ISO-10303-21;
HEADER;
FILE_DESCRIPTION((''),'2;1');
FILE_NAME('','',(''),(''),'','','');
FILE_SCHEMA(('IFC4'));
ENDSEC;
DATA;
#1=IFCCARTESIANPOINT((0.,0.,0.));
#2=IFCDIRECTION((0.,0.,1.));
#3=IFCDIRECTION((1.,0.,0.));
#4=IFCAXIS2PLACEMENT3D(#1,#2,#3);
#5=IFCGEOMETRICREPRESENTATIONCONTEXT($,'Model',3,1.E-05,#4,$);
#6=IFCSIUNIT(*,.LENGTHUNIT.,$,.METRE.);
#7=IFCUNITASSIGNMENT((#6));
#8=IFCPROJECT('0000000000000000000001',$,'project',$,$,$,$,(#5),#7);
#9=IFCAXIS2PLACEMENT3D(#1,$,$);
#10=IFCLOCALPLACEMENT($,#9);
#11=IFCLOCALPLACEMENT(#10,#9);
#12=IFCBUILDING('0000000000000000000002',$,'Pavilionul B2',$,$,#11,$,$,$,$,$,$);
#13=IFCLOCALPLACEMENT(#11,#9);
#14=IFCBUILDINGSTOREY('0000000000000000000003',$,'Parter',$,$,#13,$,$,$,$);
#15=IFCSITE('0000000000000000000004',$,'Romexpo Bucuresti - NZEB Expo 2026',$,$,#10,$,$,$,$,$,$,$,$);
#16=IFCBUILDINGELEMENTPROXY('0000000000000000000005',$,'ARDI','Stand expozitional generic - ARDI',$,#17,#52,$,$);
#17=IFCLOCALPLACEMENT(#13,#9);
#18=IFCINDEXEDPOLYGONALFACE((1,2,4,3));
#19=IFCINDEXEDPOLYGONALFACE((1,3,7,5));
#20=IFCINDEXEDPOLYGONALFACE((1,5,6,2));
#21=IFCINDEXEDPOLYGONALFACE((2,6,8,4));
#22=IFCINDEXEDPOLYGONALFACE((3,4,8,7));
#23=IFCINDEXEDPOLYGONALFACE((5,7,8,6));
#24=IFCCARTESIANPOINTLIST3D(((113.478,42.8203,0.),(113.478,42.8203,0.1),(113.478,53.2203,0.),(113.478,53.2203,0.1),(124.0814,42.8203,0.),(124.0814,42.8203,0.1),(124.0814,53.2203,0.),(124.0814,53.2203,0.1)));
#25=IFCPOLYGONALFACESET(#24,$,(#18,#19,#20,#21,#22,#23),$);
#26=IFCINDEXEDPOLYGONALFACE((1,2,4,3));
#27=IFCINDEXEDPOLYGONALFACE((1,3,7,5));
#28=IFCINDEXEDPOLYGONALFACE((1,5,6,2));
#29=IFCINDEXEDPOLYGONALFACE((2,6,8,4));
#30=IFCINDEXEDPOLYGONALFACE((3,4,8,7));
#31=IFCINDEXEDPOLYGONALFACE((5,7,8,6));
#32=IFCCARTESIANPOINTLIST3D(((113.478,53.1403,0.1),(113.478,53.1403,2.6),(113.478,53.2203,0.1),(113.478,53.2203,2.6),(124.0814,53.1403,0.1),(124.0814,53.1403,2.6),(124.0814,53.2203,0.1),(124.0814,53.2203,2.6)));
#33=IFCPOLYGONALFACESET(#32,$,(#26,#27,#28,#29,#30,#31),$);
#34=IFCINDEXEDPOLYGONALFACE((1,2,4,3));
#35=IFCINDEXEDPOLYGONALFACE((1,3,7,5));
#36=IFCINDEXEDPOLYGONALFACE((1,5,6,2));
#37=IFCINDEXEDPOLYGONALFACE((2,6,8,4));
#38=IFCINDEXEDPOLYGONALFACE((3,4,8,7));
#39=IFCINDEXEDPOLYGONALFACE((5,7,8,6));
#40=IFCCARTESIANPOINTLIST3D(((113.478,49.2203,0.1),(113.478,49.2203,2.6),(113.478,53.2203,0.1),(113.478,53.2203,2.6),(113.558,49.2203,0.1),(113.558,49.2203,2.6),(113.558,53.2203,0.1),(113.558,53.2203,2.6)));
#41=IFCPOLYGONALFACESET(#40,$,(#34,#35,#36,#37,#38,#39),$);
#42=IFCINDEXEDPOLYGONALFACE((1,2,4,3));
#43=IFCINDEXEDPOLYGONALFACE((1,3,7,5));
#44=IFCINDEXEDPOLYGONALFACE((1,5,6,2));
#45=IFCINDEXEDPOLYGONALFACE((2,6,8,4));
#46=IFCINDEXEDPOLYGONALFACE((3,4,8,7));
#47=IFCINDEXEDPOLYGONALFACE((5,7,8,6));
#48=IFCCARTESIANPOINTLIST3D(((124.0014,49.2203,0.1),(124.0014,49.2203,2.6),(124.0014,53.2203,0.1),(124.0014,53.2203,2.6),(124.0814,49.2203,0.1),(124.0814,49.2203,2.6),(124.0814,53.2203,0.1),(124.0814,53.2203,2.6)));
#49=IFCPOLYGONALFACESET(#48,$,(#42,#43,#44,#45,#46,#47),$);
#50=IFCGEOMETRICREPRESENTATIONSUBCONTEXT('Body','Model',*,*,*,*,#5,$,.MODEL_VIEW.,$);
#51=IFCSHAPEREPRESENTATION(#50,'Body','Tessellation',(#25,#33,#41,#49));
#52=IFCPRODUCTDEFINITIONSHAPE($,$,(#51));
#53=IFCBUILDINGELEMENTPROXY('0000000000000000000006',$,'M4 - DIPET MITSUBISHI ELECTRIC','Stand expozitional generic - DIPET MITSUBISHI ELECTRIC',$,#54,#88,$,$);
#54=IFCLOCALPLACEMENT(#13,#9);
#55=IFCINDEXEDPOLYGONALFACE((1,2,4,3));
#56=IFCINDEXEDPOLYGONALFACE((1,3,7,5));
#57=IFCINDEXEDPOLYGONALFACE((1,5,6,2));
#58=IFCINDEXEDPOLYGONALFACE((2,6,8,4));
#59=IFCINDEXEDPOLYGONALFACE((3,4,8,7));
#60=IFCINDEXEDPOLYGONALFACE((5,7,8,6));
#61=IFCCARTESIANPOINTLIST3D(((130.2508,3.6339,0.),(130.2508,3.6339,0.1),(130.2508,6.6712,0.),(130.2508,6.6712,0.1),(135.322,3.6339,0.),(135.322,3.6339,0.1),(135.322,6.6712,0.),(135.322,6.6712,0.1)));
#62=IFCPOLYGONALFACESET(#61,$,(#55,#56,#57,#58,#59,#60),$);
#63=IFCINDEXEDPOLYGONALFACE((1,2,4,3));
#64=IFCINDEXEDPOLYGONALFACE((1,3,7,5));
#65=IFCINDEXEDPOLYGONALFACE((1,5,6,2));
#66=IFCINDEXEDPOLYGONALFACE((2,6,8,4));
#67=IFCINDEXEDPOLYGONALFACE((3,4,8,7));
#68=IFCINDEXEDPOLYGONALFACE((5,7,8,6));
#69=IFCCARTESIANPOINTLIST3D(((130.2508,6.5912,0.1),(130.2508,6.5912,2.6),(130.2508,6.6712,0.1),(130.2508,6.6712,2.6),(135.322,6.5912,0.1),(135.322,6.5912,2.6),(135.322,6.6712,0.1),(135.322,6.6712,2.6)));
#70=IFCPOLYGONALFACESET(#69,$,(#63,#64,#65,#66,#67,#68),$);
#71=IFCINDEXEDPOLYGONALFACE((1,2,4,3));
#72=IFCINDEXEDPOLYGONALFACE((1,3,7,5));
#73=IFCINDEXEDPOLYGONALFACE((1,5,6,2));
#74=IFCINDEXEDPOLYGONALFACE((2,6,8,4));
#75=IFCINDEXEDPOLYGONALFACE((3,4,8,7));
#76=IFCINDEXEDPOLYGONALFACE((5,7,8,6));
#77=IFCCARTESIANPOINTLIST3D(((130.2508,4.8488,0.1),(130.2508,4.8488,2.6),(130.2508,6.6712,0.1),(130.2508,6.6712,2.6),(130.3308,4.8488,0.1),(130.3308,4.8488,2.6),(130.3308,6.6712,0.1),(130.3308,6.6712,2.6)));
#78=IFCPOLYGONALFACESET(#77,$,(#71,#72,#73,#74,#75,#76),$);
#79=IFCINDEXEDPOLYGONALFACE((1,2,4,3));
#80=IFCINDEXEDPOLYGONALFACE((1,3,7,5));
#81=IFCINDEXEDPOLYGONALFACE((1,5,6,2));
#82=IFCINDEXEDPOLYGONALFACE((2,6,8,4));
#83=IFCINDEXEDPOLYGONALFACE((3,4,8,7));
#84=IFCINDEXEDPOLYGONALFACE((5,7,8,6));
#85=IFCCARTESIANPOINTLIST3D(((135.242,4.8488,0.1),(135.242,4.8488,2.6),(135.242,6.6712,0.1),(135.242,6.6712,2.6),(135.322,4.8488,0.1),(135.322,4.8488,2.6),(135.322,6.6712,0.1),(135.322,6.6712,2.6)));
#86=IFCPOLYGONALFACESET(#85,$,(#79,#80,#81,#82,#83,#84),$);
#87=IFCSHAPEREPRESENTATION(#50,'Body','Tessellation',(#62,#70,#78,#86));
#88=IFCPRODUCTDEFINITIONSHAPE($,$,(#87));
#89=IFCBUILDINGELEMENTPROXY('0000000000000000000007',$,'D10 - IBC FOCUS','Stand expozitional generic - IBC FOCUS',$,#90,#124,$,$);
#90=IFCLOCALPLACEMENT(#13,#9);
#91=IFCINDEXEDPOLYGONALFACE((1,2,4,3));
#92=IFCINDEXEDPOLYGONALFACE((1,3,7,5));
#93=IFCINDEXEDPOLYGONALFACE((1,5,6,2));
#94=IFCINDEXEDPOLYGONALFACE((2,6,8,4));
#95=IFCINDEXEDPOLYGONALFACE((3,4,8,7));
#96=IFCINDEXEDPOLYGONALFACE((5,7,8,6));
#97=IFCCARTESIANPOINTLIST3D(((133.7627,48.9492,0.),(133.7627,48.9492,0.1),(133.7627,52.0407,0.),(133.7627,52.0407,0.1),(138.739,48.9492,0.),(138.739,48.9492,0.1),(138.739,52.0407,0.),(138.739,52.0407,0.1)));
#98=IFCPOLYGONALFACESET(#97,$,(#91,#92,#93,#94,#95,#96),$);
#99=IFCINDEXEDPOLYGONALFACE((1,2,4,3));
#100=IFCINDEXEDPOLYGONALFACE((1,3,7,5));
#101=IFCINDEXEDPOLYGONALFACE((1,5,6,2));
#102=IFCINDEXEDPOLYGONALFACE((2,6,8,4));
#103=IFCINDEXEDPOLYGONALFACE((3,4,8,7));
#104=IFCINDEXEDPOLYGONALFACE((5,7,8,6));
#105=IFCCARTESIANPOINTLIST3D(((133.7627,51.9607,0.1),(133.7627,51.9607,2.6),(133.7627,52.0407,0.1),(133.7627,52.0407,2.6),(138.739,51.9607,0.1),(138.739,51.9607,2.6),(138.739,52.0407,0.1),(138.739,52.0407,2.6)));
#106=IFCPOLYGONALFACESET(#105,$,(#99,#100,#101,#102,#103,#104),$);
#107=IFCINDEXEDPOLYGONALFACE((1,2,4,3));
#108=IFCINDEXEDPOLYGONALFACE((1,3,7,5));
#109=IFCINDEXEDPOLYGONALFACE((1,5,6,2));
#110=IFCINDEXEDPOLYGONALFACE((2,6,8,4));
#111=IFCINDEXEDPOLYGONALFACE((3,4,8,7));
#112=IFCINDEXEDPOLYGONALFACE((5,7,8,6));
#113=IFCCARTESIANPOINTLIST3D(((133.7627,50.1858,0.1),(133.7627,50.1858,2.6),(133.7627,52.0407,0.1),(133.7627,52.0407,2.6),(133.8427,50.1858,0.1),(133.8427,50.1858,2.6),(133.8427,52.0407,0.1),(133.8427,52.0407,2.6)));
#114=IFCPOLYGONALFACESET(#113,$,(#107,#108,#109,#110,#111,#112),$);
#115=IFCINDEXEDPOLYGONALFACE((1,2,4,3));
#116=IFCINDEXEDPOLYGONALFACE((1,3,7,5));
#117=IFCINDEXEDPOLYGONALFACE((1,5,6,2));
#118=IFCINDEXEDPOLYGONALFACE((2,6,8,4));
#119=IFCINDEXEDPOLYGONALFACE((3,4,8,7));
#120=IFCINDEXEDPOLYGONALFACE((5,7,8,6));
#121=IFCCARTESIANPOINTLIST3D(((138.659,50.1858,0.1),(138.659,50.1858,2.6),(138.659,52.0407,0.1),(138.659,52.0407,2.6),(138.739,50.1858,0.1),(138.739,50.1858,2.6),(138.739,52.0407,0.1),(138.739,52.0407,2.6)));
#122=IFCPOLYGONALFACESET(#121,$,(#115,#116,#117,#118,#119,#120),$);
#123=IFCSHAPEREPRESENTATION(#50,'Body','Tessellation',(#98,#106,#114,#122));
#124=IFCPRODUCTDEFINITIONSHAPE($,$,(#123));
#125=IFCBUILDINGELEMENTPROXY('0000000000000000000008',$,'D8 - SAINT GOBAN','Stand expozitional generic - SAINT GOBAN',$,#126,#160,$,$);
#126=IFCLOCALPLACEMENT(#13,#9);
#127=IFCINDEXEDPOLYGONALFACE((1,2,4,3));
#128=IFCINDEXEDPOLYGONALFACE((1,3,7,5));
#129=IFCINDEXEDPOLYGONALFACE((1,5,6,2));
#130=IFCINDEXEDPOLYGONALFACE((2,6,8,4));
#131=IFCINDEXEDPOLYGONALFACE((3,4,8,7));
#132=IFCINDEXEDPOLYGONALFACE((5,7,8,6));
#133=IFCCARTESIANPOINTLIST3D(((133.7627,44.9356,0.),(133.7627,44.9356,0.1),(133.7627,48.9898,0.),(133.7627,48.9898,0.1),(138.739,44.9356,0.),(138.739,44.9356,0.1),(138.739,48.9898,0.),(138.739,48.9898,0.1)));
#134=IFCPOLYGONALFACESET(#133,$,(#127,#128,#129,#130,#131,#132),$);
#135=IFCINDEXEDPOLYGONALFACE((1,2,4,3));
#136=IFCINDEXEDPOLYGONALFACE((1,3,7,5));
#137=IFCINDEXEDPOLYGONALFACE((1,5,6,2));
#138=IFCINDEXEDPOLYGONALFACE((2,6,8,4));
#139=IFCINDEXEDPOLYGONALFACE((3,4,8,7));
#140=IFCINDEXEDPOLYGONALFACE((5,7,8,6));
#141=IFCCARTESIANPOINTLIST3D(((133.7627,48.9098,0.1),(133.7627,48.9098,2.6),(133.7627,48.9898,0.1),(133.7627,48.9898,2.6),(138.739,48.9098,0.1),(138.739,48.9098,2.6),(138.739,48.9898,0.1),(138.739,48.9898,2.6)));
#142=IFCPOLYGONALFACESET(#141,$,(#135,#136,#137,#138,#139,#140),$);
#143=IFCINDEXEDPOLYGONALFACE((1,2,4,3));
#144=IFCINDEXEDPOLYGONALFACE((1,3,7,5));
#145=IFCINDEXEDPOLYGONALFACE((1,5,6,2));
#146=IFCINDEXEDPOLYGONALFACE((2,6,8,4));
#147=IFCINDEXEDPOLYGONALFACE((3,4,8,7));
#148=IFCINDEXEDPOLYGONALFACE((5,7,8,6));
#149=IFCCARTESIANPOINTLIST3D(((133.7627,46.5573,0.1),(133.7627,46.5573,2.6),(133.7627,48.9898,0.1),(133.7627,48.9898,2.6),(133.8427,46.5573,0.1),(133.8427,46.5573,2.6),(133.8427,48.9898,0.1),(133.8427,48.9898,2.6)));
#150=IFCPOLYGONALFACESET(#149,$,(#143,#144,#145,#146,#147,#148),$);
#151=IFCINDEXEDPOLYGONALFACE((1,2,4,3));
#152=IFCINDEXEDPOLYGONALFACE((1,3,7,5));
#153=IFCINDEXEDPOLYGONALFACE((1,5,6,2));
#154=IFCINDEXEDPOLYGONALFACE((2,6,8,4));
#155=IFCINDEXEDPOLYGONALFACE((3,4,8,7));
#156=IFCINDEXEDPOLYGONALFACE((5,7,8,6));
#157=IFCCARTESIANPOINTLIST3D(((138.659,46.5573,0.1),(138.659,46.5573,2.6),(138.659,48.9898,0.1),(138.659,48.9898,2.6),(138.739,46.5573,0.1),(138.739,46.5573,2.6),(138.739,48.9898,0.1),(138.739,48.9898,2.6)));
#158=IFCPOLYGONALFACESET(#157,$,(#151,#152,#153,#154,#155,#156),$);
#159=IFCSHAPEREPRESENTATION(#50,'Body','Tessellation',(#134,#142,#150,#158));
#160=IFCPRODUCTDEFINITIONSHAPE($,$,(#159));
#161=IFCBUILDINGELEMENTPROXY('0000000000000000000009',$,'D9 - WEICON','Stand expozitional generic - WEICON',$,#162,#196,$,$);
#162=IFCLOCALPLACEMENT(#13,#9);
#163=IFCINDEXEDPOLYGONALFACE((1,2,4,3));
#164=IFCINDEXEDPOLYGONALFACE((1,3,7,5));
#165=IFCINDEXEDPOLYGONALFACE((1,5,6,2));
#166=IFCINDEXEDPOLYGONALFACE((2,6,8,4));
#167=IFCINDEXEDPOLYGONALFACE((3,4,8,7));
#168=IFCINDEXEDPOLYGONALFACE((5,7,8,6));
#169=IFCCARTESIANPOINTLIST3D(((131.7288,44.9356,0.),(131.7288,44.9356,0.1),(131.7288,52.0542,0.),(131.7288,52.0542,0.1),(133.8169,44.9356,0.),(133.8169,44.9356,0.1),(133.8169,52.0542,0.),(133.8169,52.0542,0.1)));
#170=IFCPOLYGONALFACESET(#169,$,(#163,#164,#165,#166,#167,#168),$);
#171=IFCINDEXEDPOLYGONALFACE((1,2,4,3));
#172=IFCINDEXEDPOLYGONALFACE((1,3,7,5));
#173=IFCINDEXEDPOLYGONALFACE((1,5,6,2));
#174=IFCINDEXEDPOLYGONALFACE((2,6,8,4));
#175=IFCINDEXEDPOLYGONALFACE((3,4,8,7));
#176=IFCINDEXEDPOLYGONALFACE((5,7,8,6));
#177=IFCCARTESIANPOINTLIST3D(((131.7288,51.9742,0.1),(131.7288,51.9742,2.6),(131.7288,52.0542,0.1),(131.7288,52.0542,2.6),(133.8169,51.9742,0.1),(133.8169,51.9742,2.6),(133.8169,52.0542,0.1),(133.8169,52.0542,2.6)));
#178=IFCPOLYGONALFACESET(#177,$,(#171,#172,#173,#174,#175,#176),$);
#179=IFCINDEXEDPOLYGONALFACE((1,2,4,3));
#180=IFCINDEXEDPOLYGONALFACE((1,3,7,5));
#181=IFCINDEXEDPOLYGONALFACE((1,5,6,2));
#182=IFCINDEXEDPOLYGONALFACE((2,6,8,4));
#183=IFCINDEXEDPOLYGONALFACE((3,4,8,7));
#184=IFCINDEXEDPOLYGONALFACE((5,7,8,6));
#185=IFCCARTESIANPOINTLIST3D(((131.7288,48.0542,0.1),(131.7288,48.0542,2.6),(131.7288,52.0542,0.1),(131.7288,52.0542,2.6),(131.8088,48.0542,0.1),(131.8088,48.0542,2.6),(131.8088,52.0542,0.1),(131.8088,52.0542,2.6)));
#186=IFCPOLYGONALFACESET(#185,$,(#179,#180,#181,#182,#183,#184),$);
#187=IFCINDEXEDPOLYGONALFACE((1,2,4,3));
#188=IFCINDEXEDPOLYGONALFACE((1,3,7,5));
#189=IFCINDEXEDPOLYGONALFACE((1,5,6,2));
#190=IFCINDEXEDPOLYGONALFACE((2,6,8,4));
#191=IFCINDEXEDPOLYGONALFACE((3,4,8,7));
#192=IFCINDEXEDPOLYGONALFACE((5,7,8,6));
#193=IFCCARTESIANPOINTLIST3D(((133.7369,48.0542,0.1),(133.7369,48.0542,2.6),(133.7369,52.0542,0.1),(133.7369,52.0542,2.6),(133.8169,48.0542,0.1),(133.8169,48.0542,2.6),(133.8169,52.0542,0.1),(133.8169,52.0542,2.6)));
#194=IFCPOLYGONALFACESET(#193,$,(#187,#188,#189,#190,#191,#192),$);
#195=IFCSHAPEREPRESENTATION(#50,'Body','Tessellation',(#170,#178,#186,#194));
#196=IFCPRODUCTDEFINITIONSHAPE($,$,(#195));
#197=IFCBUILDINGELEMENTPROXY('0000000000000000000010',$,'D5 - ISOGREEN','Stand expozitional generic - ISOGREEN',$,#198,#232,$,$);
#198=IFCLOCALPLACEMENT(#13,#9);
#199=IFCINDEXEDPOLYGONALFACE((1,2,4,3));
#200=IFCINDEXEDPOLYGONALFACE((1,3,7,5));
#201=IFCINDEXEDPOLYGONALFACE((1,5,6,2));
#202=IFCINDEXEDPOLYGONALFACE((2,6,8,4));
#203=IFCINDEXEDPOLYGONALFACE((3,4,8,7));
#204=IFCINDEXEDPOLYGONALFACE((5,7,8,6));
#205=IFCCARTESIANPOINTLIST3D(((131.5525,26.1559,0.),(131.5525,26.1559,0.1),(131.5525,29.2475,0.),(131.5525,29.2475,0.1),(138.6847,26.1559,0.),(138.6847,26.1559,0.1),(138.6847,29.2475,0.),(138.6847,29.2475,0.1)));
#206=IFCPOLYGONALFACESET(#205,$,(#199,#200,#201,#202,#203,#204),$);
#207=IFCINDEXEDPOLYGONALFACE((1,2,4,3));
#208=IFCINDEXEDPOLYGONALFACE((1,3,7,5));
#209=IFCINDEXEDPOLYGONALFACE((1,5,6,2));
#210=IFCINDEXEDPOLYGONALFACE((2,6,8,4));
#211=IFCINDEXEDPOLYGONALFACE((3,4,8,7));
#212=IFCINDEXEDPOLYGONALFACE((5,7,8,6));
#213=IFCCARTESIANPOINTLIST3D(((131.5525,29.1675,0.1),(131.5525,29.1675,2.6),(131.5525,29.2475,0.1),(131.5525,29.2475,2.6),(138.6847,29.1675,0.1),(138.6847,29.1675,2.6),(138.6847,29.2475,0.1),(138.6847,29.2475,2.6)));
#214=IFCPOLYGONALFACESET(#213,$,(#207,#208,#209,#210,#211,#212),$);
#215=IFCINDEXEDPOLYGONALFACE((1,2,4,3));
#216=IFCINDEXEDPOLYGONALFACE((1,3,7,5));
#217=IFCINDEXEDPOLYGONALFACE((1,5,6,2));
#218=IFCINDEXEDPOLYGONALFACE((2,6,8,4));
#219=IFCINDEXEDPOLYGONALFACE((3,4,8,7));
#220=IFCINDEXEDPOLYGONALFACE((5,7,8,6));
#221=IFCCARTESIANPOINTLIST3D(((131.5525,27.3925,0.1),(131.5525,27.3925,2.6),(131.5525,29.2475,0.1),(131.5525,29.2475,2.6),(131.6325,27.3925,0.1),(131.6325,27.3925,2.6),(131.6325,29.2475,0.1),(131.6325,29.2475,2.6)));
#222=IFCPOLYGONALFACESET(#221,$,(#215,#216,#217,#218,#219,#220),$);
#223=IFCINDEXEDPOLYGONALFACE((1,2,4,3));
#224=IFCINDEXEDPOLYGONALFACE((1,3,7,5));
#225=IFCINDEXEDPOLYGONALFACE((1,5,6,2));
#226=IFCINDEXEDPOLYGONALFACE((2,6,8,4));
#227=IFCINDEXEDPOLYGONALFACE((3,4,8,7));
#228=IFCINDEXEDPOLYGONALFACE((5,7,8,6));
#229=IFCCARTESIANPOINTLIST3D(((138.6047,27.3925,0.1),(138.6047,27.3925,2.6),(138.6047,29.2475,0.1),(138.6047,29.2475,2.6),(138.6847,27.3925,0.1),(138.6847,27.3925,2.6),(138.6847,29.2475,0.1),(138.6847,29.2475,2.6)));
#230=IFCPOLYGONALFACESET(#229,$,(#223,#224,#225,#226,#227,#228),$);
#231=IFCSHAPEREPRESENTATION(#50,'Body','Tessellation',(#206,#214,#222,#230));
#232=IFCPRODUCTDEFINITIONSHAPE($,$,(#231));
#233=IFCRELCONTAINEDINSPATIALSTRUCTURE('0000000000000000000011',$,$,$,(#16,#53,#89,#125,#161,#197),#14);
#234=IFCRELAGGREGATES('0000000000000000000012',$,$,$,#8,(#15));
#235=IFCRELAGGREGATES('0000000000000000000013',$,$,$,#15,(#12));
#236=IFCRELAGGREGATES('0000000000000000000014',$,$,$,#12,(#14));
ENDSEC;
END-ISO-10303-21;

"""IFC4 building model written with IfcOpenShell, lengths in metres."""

from ifc_helpers import new_model, si_unit, frame, frame_2d, origin, origin_with_axes, place, context, subcontext, project, spatial, rectangle, extrude, element, save


model = new_model("IFC4")

# Units and contexts
model_context = context("Model", 3, precision=1e-05, world=origin_with_axes())
body_context = subcontext(model_context, "Body", "Model", "MODEL_VIEW")
ifc_project = project(units=[si_unit("LENGTHUNIT", "METRE")], contexts=[model_context])

# Site, building, storey
site_placement = place(None, origin())
site = spatial("IfcSite", under=ifc_project, at=site_placement, Name="Romexpo Bucuresti - NZEB Expo 2026")
building_placement = place(site_placement, origin())
building = spatial("IfcBuilding", under=site, at=building_placement, Name="Pavilionul B2")
storey_placement = place(building_placement, origin())
storey = spatial("IfcBuildingStorey", under=building, at=storey_placement, Name="Parter")

# Building element proxies
proxy_1_placement = place(storey_placement, frame((113.478, 42.8203, 0.0), z_axis=(0.0, 0.0, 1.0), x_axis=(1.0, 0.0, 0.0)))
element("IfcBuildingElementProxy", 1, at=proxy_1_placement, inside=storey, Name="ARDI", Description="Stand expozitional generic - ARDI", context=body_context, shape_type="SweptSolid", body=[
    extrude(rectangle(XDim=10.6034, YDim=10.4, at=frame_2d((5.3017, 5.2))), origin(), (0.0, 0.0, 1.0), 0.1),
    extrude(rectangle(XDim=10.6034, YDim=0.08, at=frame_2d((5.3017, 10.36))), frame((0.0, 0.0, 0.1)), (0.0, 0.0, 1.0), 2.5),
    extrude(rectangle(XDim=0.08, YDim=4.0, at=frame_2d((0.04, 8.4))), frame((0.0, 0.0, 0.1)), (0.0, 0.0, 1.0), 2.5),
    extrude(rectangle(XDim=0.08, YDim=4.0, at=frame_2d((10.5634, 8.4))), frame((0.0, 0.0, 0.1)), (0.0, 0.0, 1.0), 2.5),
])
proxy_2_placement = place(storey_placement, frame((130.2508, 3.6339, 0.0), z_axis=(0.0, 0.0, 1.0), x_axis=(1.0, 0.0, 0.0)))
element("IfcBuildingElementProxy", 2, at=proxy_2_placement, inside=storey, Name="M4 - DIPET MITSUBISHI ELECTRIC", Description="Stand expozitional generic - DIPET MITSUBISHI ELECTRIC", context=body_context, shape_type="SweptSolid", body=[
    extrude(rectangle(XDim=5.0712, YDim=3.0373, at=frame_2d((2.5356, 1.5186))), origin(), (0.0, 0.0, 1.0), 0.1),
    extrude(rectangle(XDim=5.0712, YDim=0.08, at=frame_2d((2.5356, 2.9973))), frame((0.0, 0.0, 0.1)), (0.0, 0.0, 1.0), 2.5),
    extrude(rectangle(XDim=0.08, YDim=1.8224, at=frame_2d((0.04, 2.1261))), frame((0.0, 0.0, 0.1)), (0.0, 0.0, 1.0), 2.5),
    extrude(rectangle(XDim=0.08, YDim=1.8224, at=frame_2d((5.0312, 2.1261))), frame((0.0, 0.0, 0.1)), (0.0, 0.0, 1.0), 2.5),
])
proxy_3_placement = place(storey_placement, frame((133.7627, 48.9492, 0.0), z_axis=(0.0, 0.0, 1.0), x_axis=(1.0, 0.0, 0.0)))
element("IfcBuildingElementProxy", 3, at=proxy_3_placement, inside=storey, Name="D10 - IBC FOCUS", Description="Stand expozitional generic - IBC FOCUS", context=body_context, shape_type="SweptSolid", body=[
    extrude(rectangle(XDim=4.9763, YDim=3.0915, at=frame_2d((2.4881, 1.5458))), origin(), (0.0, 0.0, 1.0), 0.1),
    extrude(rectangle(XDim=4.9763, YDim=0.08, at=frame_2d((2.4881, 3.0515))), frame((0.0, 0.0, 0.1)), (0.0, 0.0, 1.0), 2.5),
    extrude(rectangle(XDim=0.08, YDim=1.8549, at=frame_2d((0.04, 2.1641))), frame((0.0, 0.0, 0.1)), (0.0, 0.0, 1.0), 2.5),
    extrude(rectangle(XDim=0.08, YDim=1.8549, at=frame_2d((4.9363, 2.1641))), frame((0.0, 0.0, 0.1)), (0.0, 0.0, 1.0), 2.5),
])
proxy_4_placement = place(storey_placement, frame((133.7627, 44.9356, 0.0), z_axis=(0.0, 0.0, 1.0), x_axis=(1.0, 0.0, 0.0)))
element("IfcBuildingElementProxy", 4, at=proxy_4_placement, inside=storey, Name="D8 - SAINT GOBAN", Description="Stand expozitional generic - SAINT GOBAN", context=body_context, shape_type="SweptSolid", body=[
    extrude(rectangle(XDim=4.9763, YDim=4.0542, at=frame_2d((2.4881, 2.0271))), origin(), (0.0, 0.0, 1.0), 0.1),
    extrude(rectangle(XDim=4.9763, YDim=0.08, at=frame_2d((2.4881, 4.0142))), frame((0.0, 0.0, 0.1)), (0.0, 0.0, 1.0), 2.5),
    extrude(rectangle(XDim=0.08, YDim=2.4325, at=frame_2d((0.04, 2.838))), frame((0.0, 0.0, 0.1)), (0.0, 0.0, 1.0), 2.5),
    extrude(rectangle(XDim=0.08, YDim=2.4325, at=frame_2d((4.9363, 2.838))), frame((0.0, 0.0, 0.1)), (0.0, 0.0, 1.0), 2.5),
])
proxy_5_placement = place(storey_placement, frame((131.7288, 44.9356, 0.0), z_axis=(0.0, 0.0, 1.0), x_axis=(1.0, 0.0, 0.0)))
element("IfcBuildingElementProxy", 5, at=proxy_5_placement, inside=storey, Name="D9 - WEICON", Description="Stand expozitional generic - WEICON", context=body_context, shape_type="SweptSolid", body=[
    extrude(rectangle(XDim=2.0881, YDim=7.1186, at=frame_2d((1.0441, 3.5593))), origin(), (0.0, 0.0, 1.0), 0.1),
    extrude(rectangle(XDim=2.0881, YDim=0.08, at=frame_2d((1.0441, 7.0786))), frame((0.0, 0.0, 0.1)), (0.0, 0.0, 1.0), 2.5),
    extrude(rectangle(XDim=0.08, YDim=4.0, at=frame_2d((0.04, 5.1186))), frame((0.0, 0.0, 0.1)), (0.0, 0.0, 1.0), 2.5),
    extrude(rectangle(XDim=0.08, YDim=4.0, at=frame_2d((2.0481, 5.1186))), frame((0.0, 0.0, 0.1)), (0.0, 0.0, 1.0), 2.5),
])
proxy_6_placement = place(storey_placement, frame((131.5525, 26.1559, 0.0), z_axis=(0.0, 0.0, 1.0), x_axis=(1.0, 0.0, 0.0)))
element("IfcBuildingElementProxy", 6, at=proxy_6_placement, inside=storey, Name="D5 - ISOGREEN", Description="Stand expozitional generic - ISOGREEN", context=body_context, shape_type="SweptSolid", body=[
    extrude(rectangle(XDim=7.1322, YDim=3.0915, at=frame_2d((3.5661, 1.5458))), origin(), (0.0, 0.0, 1.0), 0.1),
    extrude(rectangle(XDim=7.1322, YDim=0.08, at=frame_2d((3.5661, 3.0515))), frame((0.0, 0.0, 0.1)), (0.0, 0.0, 1.0), 2.5),
    extrude(rectangle(XDim=0.08, YDim=1.8549, at=frame_2d((0.04, 2.1641))), frame((0.0, 0.0, 0.1)), (0.0, 0.0, 1.0), 2.5),
    extrude(rectangle(XDim=0.08, YDim=1.8549, at=frame_2d((7.0922, 2.1641))), frame((0.0, 0.0, 0.1)), (0.0, 0.0, 1.0), 2.5),
])

save(model, "model.ifc")
